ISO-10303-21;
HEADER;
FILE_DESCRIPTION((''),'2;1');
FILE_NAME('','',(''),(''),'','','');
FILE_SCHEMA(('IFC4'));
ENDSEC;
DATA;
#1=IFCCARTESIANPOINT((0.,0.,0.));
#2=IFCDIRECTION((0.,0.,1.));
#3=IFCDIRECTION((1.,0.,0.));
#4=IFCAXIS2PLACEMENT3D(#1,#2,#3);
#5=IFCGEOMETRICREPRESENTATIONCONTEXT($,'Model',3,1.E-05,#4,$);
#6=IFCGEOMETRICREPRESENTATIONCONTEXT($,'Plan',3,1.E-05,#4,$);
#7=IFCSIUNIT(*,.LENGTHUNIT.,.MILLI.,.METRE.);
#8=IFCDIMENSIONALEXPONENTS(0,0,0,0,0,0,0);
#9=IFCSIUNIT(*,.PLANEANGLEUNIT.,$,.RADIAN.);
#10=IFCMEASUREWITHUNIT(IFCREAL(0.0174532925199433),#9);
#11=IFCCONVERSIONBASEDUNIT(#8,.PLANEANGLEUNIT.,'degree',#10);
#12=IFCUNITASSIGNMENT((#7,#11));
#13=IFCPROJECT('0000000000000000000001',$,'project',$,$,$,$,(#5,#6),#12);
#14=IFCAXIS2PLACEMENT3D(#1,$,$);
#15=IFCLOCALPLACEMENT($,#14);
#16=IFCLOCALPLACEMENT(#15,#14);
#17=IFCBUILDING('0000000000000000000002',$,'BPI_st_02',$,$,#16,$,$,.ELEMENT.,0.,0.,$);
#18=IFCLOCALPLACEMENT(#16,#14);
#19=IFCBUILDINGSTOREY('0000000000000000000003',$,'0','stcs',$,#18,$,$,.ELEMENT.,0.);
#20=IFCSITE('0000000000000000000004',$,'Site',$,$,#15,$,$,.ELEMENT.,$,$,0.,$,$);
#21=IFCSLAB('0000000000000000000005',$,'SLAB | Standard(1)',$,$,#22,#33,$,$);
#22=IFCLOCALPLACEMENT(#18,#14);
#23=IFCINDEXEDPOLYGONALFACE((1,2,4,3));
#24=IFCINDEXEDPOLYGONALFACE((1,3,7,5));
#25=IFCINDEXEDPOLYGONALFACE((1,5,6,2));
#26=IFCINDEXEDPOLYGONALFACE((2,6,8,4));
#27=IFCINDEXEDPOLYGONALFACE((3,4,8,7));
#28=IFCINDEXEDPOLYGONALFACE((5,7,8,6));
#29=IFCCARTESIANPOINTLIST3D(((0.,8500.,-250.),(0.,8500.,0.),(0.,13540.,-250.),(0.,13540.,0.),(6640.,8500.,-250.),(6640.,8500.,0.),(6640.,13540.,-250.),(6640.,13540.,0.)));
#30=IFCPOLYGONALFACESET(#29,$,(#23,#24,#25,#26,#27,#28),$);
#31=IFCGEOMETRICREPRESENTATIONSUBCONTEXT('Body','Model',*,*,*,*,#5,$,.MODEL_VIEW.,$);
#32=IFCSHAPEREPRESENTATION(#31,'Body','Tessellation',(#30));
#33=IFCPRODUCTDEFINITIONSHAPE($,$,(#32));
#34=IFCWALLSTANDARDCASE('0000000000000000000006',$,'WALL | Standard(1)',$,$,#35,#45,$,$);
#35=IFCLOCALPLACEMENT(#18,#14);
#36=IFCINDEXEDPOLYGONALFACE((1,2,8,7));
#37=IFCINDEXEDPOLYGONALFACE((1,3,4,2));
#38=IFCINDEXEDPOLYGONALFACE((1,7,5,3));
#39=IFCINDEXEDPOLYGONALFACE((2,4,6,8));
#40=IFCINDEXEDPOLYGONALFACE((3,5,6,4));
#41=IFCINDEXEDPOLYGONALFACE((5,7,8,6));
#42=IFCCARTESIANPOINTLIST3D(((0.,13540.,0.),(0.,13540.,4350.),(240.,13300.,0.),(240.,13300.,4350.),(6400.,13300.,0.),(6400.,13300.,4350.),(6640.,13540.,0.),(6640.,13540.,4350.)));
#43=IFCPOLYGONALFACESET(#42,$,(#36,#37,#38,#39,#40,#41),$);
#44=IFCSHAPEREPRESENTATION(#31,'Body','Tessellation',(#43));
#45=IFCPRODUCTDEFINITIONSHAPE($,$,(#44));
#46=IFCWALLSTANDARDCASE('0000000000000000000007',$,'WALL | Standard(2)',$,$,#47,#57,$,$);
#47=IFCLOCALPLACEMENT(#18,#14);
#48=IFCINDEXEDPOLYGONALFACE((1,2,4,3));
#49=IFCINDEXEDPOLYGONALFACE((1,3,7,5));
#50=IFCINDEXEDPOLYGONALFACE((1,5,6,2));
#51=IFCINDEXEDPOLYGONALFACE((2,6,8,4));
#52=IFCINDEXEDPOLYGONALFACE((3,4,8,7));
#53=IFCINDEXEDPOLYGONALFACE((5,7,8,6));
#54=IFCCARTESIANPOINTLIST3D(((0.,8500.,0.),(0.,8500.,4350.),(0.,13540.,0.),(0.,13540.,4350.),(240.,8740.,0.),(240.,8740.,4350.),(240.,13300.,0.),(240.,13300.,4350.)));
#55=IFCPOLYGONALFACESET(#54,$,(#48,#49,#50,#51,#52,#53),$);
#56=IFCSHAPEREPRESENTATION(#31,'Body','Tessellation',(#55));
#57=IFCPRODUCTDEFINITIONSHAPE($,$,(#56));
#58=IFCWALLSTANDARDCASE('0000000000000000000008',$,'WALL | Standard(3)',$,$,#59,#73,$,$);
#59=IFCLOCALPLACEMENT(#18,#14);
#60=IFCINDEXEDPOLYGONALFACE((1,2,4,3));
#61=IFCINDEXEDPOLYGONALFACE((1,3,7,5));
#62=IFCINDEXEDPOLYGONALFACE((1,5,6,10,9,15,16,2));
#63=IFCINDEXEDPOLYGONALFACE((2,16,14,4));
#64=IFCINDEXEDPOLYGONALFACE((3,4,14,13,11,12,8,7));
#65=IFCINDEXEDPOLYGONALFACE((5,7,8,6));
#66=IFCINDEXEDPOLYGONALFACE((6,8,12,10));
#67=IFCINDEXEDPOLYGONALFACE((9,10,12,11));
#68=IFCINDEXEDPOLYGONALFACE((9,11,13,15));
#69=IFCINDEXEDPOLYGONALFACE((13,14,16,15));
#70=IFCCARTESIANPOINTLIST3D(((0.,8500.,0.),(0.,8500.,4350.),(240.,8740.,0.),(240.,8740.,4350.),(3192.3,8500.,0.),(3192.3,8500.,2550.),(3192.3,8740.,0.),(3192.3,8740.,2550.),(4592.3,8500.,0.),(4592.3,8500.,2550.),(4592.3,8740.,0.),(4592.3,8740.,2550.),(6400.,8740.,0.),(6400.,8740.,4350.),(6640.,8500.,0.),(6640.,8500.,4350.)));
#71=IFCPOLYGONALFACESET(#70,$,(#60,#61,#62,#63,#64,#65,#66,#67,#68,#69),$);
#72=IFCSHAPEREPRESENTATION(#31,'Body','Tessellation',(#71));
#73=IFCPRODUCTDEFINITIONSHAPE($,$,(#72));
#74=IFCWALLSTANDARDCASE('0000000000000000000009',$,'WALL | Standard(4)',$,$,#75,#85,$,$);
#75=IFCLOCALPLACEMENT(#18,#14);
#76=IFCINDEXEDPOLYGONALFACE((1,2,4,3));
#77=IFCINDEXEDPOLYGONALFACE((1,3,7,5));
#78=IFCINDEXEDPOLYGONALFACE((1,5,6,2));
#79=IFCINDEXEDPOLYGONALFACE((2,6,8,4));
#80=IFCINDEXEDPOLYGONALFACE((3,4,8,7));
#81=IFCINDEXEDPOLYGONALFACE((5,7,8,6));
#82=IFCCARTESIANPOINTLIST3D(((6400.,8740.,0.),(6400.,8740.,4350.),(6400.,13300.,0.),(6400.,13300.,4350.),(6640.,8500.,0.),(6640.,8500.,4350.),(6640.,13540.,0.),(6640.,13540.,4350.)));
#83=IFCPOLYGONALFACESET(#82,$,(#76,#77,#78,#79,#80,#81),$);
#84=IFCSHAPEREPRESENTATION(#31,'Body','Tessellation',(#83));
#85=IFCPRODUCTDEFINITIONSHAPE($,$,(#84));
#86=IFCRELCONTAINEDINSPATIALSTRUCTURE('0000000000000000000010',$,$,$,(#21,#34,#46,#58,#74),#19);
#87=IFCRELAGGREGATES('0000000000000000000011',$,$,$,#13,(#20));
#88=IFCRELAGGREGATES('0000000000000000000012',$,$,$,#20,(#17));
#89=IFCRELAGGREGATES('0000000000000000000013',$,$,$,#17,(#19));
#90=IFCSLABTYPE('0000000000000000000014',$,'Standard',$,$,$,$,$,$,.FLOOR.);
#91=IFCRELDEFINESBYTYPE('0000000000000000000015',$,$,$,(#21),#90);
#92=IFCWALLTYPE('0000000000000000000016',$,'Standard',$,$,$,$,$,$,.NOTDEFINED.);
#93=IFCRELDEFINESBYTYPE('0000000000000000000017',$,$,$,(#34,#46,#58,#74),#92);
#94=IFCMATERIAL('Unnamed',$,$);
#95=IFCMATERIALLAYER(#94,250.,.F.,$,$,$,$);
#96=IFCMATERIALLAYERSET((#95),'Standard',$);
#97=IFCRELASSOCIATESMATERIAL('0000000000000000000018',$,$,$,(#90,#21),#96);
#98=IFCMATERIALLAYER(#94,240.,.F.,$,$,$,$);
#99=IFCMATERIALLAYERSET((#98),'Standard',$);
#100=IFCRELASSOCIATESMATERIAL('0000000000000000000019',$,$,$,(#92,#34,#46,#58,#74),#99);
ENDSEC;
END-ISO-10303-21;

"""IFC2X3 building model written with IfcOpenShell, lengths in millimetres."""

from ifc_helpers import new_model, entity, si_unit, converted_unit, frame, frame_2d, origin, origin_with_axes, origin_2d_with_axis, place, context, subcontext, project, spatial, polyline, segment, composite_curve, rectangle, outline, extrude, material, layer, layer_set, layer_usage, type_object, element, save


model = new_model("IFC2X3")

# Units and contexts
model_context = context("Model", 3, precision=1e-05, world=origin_with_axes())
plan_context = context("Plan", 3, precision=1e-05, world=origin_with_axes())
body_context = subcontext(model_context, "Body", "Model", "MODEL_VIEW")
ifc_project = project(units=[si_unit("LENGTHUNIT", "METRE", prefix="MILLI"), converted_unit("PLANEANGLEUNIT", "degree", entity("IfcReal", 0.0174532925199433), si_unit("PLANEANGLEUNIT", "RADIAN"), dimensions=[0, 0, 0, 0, 0, 0, 0])], contexts=[model_context, plan_context])

# Site, building, storey
site_placement = place(None, origin())
site = spatial("IfcSite", under=ifc_project, at=site_placement, Name="Site", CompositionType="ELEMENT", RefElevation=0.0)
building_placement = place(site_placement, origin())
building = spatial("IfcBuilding", under=site, at=building_placement, Name="BPI_st_02", CompositionType="ELEMENT", ElevationOfRefHeight=0.0, ElevationOfTerrain=0.0)
storey_placement = place(building_placement, origin())
storey = spatial("IfcBuildingStorey", under=building, at=storey_placement, Name="0", Description="stcs", CompositionType="ELEMENT", Elevation=0.0)

# Slab
ifc_material = material(Name="Unnamed")
ifc_layer_1 = layer(ifc_material, 250.0, ventilated=False)
ifc_layer_set_1 = layer_set([ifc_layer_1], Name="Standard")
ifc_layer_usage_1 = layer_usage(ifc_layer_set_1, "AXIS3", "POSITIVE", 0.0)
slab_type = type_object("IfcSlabType", Name="Standard", PredefinedType="FLOOR", material=ifc_layer_set_1)
slab_placement = place(storey_placement, frame((22540.0, 13540.0, 0.0), z_axis=(0.0, 0.0, 1.0), x_axis=(-1.0, 0.0, 0.0)))
element("IfcSlab", 1, at=slab_placement, inside=storey, type_object=slab_type, material=ifc_layer_usage_1, Name="SLAB | Standard(1)", context=body_context, shape_type="SweptSolid", body=[
    extrude(rectangle(XDim=6640.0, YDim=5040.0, at=frame_2d((19220.0, 2520.0), x_axis=(1.0, 0.0))), frame((0.0, 0.0, -250.0)), (0.0, 0.0, 1.0), 250.0),
])

# Walls
ifc_layer_2 = layer(ifc_material, 240.0, ventilated=False)
ifc_layer_set_2 = layer_set([ifc_layer_2], Name="Standard")
ifc_layer_usage_2 = layer_usage(ifc_layer_set_2, "AXIS2", "POSITIVE", -120.0)
wall_type = type_object("IfcWallType", Name="Standard", PredefinedType="NOTDEFINED", material=ifc_layer_set_2)
wall_1_placement = place(storey_placement, frame((120.0, 13420.0, 0.0)))
element("IfcWallStandardCase", 2, at=wall_1_placement, inside=storey, type_object=wall_type, material=ifc_layer_usage_2, Name="WALL | Standard(1)", context=body_context, shape_type="SweptSolid", body=[
    extrude(outline(composite_curve([segment(polyline([(-120.0, 120.0), (120.0, -120.0)]), True, "CONTINUOUS"), segment(polyline([(120.0, -120.0), (6280.0, -120.0)]), True, "CONTINUOUS"), segment(polyline([(6280.0, -120.0), (6520.0, 120.0)]), True, "CONTINUOUS"), segment(polyline([(6520.0, 120.0), (-120.0, 120.0)]), True, "CONTINUOUS")], self_intersect=False)), origin(), (0.0, 0.0, 1.0), 4350.0),
])
ifc_layer_usage_3 = layer_usage(ifc_layer_set_2, "AXIS2", "POSITIVE", -120.0)
wall_2_placement = place(storey_placement, frame((120.0, 8620.0, 0.0), z_axis=(0.0, 0.0, 1.0), x_axis=(0.0, 1.0, 0.0)))
element("IfcWallStandardCase", 3, at=wall_2_placement, inside=storey, type_object=wall_type, material=ifc_layer_usage_3, Name="WALL | Standard(2)", context=body_context, shape_type="SweptSolid", body=[
    extrude(outline(composite_curve([segment(polyline([(-120.0, 120.0), (120.0, -120.0)]), True, "CONTINUOUS"), segment(polyline([(120.0, -120.0), (4680.0, -120.0)]), True, "CONTINUOUS"), segment(polyline([(4680.0, -120.0), (4920.0, 120.0)]), True, "CONTINUOUS"), segment(polyline([(4920.0, 120.0), (-120.0, 120.0)]), True, "CONTINUOUS")], self_intersect=False)), origin(), (0.0, 0.0, 1.0), 4350.0),
])

# Wall, opening
ifc_layer_usage_4 = layer_usage(ifc_layer_set_2, "AXIS2", "POSITIVE", -120.0)
wall_3_placement = place(storey_placement, frame((0.0, 8620.0, 0.0)))
wall_3 = element("IfcWallStandardCase", 4, at=wall_3_placement, inside=storey, type_object=wall_type, material=ifc_layer_usage_4, Name="WALL | Standard(3)", context=body_context, shape_type="SweptSolid", body=[
    extrude(outline(composite_curve([segment(polyline([(240.0, 120.0), (0.0, -120.0)]), True, "CONTINUOUS"), segment(polyline([(0.0, -120.0), (6640.0, -120.0)]), True, "CONTINUOUS"), segment(polyline([(6640.0, -120.0), (6400.0, 120.0)]), True, "CONTINUOUS"), segment(polyline([(6400.0, 120.0), (240.0, 120.0)]), True, "CONTINUOUS")], self_intersect=False)), origin(), (0.0, 0.0, 1.0), 4350.0),
])
opening_placement = place(wall_3_placement, frame((3192.3, 0.0, 0.0)))
element("IfcOpeningElement", 5, at=opening_placement, cuts=wall_3, context=body_context, shape_type="SweptSolid", body=[
    extrude(rectangle(XDim=1400.0, YDim=2550.0, at=origin_2d_with_axis()), frame((700.0, 120.0, 1275.0), z_axis=(0.0, -1.0, 0.0), x_axis=(1.0, 0.0, 0.0)), (0.0, 0.0, 1.0), 240.0),
])

# Wall
ifc_layer_usage_5 = layer_usage(ifc_layer_set_2, "AXIS2", "POSITIVE", -120.0)
wall_4_placement = place(storey_placement, frame((6520.0, 8620.0, 0.0), z_axis=(0.0, 0.0, 1.0), x_axis=(0.0, 1.0, 0.0)))
element("IfcWallStandardCase", 6, at=wall_4_placement, inside=storey, type_object=wall_type, material=ifc_layer_usage_5, Name="WALL | Standard(4)", context=body_context, shape_type="SweptSolid", body=[
    extrude(outline(composite_curve([segment(polyline([(120.0, 120.0), (-120.0, -120.0)]), True, "CONTINUOUS"), segment(polyline([(-120.0, -120.0), (4920.0, -120.0)]), True, "CONTINUOUS"), segment(polyline([(4920.0, -120.0), (4680.0, 120.0)]), True, "CONTINUOUS"), segment(polyline([(4680.0, 120.0), (120.0, 120.0)]), True, "CONTINUOUS")], self_intersect=False)), origin(), (0.0, 0.0, 1.0), 4350.0),
])

save(model, "model.ifc")
